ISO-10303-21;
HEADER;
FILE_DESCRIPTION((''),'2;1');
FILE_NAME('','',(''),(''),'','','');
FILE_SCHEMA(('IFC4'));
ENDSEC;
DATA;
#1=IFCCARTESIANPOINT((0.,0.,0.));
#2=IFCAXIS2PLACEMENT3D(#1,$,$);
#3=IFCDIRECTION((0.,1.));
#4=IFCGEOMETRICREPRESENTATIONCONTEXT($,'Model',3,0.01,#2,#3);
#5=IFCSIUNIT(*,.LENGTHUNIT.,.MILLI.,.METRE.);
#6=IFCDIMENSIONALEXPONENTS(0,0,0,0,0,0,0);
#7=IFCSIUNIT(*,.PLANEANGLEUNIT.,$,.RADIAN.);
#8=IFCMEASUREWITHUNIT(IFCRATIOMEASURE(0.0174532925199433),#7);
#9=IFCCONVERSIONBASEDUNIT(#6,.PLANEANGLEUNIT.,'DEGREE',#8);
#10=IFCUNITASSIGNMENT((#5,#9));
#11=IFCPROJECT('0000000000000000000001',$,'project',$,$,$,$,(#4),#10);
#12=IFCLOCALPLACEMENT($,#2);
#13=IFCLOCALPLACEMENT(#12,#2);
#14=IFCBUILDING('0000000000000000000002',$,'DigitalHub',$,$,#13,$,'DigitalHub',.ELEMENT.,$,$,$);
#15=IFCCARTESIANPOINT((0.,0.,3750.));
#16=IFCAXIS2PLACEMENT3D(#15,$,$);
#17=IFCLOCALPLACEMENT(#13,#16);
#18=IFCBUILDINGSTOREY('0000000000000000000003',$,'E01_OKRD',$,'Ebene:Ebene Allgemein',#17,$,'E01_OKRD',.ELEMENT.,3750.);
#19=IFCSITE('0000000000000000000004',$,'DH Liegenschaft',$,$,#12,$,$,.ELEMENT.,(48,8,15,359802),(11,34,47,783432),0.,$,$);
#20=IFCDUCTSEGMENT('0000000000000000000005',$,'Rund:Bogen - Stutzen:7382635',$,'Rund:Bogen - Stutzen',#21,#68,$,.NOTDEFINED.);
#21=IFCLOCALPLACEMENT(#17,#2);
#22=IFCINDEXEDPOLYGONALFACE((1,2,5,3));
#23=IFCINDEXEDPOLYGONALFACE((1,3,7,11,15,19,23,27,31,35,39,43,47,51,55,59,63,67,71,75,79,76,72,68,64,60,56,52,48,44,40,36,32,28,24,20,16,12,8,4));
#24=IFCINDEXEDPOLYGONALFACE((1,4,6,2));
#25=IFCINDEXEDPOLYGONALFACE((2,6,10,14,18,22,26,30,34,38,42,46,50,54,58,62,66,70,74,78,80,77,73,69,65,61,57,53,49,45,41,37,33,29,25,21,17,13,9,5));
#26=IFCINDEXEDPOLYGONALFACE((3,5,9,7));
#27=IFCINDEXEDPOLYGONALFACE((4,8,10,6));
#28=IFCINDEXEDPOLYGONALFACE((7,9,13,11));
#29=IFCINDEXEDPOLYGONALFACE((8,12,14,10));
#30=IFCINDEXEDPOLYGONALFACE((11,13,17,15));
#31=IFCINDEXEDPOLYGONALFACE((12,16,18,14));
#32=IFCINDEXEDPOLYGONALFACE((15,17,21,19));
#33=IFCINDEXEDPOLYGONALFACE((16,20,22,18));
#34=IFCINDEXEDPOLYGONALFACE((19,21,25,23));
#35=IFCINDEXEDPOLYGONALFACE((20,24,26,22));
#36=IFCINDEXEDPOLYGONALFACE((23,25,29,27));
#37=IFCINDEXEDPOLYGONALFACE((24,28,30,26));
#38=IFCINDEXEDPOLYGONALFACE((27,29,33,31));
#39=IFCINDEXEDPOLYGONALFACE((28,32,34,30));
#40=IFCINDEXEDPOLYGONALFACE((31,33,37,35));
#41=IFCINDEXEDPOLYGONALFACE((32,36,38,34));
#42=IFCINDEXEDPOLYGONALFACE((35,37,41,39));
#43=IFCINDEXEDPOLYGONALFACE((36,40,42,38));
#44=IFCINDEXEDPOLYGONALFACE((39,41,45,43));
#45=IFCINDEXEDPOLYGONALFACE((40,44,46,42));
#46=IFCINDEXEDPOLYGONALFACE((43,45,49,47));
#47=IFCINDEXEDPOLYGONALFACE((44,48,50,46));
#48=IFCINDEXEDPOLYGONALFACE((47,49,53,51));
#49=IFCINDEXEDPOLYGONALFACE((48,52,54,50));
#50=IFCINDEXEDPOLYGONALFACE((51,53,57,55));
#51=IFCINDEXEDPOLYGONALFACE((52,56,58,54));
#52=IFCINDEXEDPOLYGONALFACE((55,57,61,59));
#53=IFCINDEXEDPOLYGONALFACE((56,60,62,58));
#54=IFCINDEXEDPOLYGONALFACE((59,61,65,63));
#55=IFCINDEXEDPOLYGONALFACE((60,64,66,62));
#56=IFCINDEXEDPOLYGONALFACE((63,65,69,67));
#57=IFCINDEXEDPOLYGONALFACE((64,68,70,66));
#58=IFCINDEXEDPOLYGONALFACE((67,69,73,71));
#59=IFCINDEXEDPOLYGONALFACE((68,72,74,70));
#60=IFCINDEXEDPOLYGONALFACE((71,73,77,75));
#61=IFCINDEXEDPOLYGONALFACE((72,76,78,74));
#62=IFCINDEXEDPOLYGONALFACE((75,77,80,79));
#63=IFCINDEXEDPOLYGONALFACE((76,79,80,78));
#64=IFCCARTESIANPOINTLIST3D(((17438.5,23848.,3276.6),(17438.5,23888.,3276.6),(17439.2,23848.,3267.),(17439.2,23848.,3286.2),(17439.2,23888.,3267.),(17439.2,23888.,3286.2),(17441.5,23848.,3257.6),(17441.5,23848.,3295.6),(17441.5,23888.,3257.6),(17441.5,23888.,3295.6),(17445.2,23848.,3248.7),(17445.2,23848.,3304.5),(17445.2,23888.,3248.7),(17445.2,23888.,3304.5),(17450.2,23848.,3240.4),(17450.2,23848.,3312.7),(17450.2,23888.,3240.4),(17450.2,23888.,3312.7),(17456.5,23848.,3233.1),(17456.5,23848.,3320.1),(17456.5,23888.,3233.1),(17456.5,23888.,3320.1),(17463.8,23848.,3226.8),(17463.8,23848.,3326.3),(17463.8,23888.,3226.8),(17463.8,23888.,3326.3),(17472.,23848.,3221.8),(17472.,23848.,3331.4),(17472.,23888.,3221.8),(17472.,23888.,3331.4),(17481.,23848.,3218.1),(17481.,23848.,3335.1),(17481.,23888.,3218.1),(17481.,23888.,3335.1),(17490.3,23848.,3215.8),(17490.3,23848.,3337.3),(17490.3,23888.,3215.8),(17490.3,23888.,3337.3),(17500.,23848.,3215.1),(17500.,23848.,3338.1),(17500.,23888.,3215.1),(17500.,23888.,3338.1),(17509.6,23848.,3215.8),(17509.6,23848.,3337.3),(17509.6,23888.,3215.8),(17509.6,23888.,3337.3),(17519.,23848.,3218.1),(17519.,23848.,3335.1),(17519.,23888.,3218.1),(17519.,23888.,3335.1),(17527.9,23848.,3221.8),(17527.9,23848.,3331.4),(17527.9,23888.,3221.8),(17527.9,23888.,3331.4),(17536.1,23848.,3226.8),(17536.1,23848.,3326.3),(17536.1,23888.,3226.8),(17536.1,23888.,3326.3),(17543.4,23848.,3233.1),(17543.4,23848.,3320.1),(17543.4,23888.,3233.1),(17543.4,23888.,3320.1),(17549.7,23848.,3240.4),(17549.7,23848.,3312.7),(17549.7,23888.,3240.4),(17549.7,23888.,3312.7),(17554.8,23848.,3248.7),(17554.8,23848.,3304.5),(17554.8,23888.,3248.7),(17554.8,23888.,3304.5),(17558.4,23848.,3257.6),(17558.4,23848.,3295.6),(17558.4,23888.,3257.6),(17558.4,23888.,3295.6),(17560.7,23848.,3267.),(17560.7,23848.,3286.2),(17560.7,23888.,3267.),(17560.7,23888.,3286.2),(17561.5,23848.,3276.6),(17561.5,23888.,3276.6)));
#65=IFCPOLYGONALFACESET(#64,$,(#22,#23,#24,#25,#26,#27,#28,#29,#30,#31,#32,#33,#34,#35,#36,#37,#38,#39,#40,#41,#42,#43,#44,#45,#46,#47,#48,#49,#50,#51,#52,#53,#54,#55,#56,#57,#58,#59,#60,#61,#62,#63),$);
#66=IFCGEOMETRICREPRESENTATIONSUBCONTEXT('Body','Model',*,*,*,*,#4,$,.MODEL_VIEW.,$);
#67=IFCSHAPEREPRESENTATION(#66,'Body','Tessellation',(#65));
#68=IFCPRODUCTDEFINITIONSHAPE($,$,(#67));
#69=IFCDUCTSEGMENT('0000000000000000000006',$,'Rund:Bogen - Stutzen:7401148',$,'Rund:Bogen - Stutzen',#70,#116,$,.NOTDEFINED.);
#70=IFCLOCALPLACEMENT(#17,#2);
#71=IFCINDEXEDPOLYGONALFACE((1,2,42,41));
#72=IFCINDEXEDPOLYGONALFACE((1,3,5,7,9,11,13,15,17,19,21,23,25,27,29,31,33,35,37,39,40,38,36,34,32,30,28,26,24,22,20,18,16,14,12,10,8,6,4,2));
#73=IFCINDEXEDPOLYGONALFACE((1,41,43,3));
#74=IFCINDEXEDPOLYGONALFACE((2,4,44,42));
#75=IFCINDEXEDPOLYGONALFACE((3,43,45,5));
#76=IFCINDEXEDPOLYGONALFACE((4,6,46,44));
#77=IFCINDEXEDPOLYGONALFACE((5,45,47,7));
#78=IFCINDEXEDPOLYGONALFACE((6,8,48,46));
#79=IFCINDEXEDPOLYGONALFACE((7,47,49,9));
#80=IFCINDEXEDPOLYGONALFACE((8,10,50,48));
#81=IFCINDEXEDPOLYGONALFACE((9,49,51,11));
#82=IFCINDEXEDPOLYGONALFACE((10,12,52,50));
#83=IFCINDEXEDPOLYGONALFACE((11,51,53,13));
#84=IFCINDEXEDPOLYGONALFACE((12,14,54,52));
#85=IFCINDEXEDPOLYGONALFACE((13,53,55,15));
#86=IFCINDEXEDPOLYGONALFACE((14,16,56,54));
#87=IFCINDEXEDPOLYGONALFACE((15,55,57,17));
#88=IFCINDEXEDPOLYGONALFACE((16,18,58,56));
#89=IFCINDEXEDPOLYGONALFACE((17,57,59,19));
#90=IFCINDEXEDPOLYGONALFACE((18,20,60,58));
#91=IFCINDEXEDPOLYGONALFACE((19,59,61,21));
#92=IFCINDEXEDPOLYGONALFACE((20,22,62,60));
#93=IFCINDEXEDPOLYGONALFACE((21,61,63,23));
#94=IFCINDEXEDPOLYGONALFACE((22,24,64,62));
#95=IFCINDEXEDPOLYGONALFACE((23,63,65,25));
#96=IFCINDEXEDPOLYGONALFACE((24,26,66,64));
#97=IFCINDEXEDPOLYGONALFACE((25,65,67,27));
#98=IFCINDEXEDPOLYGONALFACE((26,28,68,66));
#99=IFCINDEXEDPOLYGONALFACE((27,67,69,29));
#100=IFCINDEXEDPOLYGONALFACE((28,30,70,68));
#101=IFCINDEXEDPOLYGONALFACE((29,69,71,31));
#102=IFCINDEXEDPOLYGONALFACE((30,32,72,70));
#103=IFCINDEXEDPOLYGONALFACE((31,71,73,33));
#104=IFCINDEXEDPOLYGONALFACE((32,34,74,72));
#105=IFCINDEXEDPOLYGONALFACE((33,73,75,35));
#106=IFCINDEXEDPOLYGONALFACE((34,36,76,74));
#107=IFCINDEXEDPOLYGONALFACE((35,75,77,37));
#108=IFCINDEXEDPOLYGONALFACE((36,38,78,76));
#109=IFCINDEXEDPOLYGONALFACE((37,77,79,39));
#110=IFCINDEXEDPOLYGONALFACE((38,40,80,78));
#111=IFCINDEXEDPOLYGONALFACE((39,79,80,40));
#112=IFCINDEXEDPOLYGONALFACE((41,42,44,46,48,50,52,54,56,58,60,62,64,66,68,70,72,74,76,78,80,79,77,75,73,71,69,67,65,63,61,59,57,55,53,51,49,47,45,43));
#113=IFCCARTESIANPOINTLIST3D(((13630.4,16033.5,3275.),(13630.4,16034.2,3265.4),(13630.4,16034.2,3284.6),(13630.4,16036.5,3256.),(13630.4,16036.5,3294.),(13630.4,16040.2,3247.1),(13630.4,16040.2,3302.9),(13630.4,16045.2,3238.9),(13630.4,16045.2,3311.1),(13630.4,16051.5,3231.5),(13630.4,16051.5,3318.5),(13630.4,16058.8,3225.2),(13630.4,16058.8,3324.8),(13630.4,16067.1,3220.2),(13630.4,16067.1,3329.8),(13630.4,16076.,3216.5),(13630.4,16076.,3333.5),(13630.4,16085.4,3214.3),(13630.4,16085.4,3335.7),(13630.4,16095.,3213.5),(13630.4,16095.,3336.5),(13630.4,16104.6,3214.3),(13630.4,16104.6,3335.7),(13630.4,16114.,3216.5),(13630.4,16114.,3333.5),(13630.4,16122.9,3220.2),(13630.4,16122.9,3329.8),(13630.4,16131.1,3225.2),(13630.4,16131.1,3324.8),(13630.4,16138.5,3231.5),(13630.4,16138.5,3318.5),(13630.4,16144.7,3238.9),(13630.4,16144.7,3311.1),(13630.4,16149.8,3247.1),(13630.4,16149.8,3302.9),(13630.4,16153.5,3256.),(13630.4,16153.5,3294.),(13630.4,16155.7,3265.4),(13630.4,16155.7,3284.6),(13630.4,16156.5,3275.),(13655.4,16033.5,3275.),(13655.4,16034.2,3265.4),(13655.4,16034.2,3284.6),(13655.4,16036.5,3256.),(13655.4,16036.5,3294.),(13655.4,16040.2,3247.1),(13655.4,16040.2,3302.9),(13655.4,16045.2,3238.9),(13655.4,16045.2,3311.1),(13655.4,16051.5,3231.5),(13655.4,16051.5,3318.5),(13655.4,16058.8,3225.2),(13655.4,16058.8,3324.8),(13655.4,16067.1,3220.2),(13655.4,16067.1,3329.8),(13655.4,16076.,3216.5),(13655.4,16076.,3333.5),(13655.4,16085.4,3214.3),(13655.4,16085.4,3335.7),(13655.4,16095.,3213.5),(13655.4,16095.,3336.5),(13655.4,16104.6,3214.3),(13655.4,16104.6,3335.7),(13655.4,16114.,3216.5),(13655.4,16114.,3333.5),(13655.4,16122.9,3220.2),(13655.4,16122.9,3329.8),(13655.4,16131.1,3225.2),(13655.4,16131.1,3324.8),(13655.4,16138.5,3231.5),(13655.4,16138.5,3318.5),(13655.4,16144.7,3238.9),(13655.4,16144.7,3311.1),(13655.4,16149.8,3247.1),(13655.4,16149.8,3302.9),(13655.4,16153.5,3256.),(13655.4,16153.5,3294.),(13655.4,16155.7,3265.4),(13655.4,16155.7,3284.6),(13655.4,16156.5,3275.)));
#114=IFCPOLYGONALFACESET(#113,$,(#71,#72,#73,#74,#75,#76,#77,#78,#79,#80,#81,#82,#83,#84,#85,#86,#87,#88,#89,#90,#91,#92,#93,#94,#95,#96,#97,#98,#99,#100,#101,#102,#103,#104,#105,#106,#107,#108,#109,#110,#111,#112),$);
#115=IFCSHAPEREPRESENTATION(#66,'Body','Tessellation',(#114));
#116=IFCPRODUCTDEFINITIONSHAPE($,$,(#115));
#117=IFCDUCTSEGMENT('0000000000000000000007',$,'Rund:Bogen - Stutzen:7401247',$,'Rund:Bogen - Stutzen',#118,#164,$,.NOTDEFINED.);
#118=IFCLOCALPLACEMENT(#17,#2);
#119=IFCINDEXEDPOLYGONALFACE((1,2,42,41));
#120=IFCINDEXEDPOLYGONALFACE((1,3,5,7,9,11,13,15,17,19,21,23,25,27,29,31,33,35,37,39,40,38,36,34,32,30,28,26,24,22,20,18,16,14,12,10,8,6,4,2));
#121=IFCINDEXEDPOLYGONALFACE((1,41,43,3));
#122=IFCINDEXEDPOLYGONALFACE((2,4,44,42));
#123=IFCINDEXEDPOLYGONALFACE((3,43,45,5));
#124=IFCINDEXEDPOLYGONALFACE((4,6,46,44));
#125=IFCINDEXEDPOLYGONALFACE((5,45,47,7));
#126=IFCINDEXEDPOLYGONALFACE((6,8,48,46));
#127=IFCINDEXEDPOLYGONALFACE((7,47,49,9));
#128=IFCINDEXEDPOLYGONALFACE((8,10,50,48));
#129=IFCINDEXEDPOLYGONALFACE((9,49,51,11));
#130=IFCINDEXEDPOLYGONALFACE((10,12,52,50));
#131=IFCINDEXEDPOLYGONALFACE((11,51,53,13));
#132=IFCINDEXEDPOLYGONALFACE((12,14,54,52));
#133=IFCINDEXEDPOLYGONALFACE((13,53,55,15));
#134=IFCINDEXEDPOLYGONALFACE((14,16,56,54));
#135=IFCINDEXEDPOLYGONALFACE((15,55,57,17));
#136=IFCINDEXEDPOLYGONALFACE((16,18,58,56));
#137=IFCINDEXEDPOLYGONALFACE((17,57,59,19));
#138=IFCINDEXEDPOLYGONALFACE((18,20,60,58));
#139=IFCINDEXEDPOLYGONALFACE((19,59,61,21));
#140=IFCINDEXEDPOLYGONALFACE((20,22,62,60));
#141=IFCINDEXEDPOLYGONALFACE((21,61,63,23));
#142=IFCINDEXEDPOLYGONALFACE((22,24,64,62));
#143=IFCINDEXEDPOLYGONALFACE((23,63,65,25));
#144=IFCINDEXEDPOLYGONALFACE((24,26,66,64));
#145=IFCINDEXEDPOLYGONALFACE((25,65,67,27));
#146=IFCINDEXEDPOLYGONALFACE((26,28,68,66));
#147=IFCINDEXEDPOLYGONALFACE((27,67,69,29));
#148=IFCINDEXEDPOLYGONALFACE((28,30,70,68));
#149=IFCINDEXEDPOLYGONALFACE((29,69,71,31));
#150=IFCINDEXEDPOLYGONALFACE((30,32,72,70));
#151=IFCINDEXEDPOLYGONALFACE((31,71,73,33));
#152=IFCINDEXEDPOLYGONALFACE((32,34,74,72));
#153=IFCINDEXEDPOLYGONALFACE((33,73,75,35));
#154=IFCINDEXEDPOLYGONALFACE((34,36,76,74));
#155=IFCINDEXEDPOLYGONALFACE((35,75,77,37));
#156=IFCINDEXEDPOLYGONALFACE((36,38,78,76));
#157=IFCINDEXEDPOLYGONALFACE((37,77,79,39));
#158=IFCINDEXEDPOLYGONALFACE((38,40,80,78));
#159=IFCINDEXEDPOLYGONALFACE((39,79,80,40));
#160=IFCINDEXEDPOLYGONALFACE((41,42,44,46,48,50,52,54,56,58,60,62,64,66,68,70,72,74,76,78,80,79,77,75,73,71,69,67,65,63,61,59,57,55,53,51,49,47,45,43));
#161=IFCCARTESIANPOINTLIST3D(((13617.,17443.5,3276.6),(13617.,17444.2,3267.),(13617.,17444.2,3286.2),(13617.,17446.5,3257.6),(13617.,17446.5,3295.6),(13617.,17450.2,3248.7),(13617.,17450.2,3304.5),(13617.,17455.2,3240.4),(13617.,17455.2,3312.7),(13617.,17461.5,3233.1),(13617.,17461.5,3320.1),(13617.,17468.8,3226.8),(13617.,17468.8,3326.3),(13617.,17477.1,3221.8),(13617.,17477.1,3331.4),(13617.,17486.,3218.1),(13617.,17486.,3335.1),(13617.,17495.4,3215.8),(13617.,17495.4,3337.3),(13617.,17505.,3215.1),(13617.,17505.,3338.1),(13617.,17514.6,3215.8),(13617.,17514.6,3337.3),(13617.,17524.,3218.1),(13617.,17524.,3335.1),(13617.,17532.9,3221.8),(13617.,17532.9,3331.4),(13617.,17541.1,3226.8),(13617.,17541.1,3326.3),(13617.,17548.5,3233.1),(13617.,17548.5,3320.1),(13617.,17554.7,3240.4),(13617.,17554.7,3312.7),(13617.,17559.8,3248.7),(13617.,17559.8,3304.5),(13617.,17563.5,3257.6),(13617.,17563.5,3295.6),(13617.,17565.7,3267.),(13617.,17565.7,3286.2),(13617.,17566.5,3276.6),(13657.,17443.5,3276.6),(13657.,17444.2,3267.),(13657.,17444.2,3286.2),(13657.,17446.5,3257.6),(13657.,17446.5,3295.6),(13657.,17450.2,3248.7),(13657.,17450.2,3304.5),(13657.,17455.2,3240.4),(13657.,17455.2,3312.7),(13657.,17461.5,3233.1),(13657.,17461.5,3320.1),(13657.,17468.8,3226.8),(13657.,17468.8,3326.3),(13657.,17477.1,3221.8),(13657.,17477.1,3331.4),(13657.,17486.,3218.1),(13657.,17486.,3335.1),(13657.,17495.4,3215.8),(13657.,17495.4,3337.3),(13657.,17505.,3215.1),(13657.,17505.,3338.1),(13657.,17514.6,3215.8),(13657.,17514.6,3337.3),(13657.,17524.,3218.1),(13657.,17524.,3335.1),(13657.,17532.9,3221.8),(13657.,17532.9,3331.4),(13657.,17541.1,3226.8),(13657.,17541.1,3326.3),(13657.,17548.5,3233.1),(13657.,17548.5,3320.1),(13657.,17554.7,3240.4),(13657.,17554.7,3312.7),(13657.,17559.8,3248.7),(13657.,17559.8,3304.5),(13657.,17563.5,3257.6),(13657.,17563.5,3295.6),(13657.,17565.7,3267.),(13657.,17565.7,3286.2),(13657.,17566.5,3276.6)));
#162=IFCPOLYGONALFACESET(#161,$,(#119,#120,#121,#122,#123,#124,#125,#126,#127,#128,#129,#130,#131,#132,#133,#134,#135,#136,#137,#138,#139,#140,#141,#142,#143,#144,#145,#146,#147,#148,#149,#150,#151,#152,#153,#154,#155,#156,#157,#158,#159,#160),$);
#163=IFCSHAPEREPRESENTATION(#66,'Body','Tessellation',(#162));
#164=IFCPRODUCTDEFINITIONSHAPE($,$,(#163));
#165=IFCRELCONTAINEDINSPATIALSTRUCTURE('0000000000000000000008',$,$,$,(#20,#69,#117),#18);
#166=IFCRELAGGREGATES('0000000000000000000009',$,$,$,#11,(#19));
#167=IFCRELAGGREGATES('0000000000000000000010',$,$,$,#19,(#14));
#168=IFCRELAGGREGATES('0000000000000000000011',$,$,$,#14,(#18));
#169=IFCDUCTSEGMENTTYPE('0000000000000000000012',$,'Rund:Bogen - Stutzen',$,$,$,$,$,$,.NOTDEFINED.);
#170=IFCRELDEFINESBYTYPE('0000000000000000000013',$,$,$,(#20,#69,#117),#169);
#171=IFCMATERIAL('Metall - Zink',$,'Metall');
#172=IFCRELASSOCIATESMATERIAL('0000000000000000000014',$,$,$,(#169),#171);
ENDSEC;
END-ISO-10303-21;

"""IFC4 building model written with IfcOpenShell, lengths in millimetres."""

from ifc_helpers import new_model, entity, si_unit, converted_unit, direction, frame, origin, place, context, subcontext, project, spatial, indexed_curve, outline, extrude, material, type_object, element, save


model = new_model("IFC4")

# Units and contexts
model_context = context("Model", 3, precision=0.01, world=origin(), true_north=direction((0.0, 1.0)))
body_context = subcontext(model_context, "Body", "Model", "MODEL_VIEW")
ifc_project = project(units=[si_unit("LENGTHUNIT", "METRE", prefix="MILLI"), converted_unit("PLANEANGLEUNIT", "DEGREE", entity("IfcRatioMeasure", 0.0174532925199433), si_unit("PLANEANGLEUNIT", "RADIAN"), dimensions=[0, 0, 0, 0, 0, 0, 0])], contexts=[model_context])

# Site, building, storey
site_placement = place(None, origin())
site = spatial("IfcSite", under=ifc_project, at=site_placement, Name="DH Liegenschaft", CompositionType="ELEMENT", RefLatitude=(48, 8, 15, 359802), RefLongitude=(11, 34, 47, 783432), RefElevation=0.0)
building_placement = place(site_placement, origin())
building = spatial("IfcBuilding", under=site, at=building_placement, Name="DigitalHub", LongName="DigitalHub", CompositionType="ELEMENT")
storey_placement = place(building_placement, frame((0.0, 0.0, 3750.0)))
storey = spatial("IfcBuildingStorey", under=building, at=storey_placement, Name="E01_OKRD", ObjectType="Ebene:Ebene Allgemein", LongName="E01_OKRD", CompositionType="ELEMENT", Elevation=3750.0)

# Shared definitions
ifc_material_1 = material(Name="Metall - Zink", Category="Metall")

# Duct segments
duct_segment_type_1 = type_object("IfcDuctSegmentType", Name="Rund:Bogen - Stutzen", PredefinedType="NOTDEFINED", material=ifc_material_1)
duct_segment_1_placement = place(storey_placement, frame((17436.9, 23848.0, 3213.5)))
element("IfcDuctSegment", 1, at=duct_segment_1_placement, inside=storey, type_object=duct_segment_type_1, Name="Rund:Bogen - Stutzen:7382635", ObjectType="Rund:Bogen - Stutzen", PredefinedType="NOTDEFINED", context=body_context, shape_type="SweptSolid", body=[
    extrude(outline(indexed_curve([(61.5, 0.0), (60.7, 9.6), (58.5, 19.0), (54.8, 27.9), (49.8, 36.1), (43.5, 43.5), (36.1, 49.8), (27.9, 54.8), (19.0, 58.5), (9.6, 60.7), (0.0, 61.5), (-9.6, 60.7), (-19.0, 58.5), (-27.9, 54.8), (-36.1, 49.8), (-43.5, 43.5), (-49.8, 36.1), (-54.8, 27.9), (-58.5, 19.0), (-60.7, 9.6), (-61.5, 0.0), (-60.7, -9.6), (-58.5, -19.0), (-54.8, -27.9), (-49.8, -36.1), (-43.5, -43.5), (-36.1, -49.8), (-27.9, -54.8), (-19.0, -58.5), (-9.6, -60.7), (0.0, -61.5), (9.6, -60.7), (19.0, -58.5), (27.9, -54.8), (36.1, -49.8), (43.5, -43.5), (49.8, -36.1), (54.8, -27.9), (58.5, -19.0), (60.7, -9.6), (61.5, 0.0)], self_intersect=False)), frame((63.1, 0.0, 63.1), z_axis=(0.0, 1.0, 0.0), x_axis=(1.0, 0.0, 0.0)), (0.0, 0.0, 1.0), 40.0),
])
duct_segment_2_placement = place(storey_placement, frame((13630.4, 16031.9, 3211.9)))
element("IfcDuctSegment", 2, at=duct_segment_2_placement, inside=storey, type_object=duct_segment_type_1, Name="Rund:Bogen - Stutzen:7401148", ObjectType="Rund:Bogen - Stutzen", PredefinedType="NOTDEFINED", context=body_context, shape_type="SweptSolid", body=[
    extrude(outline(indexed_curve([(61.5, 0.0), (60.7, 9.6), (58.5, 19.0), (54.8, 27.9), (49.8, 36.1), (43.5, 43.5), (36.1, 49.8), (27.9, 54.8), (19.0, 58.5), (9.6, 60.7), (0.0, 61.5), (-9.6, 60.7), (-19.0, 58.5), (-27.9, 54.8), (-36.1, 49.8), (-43.5, 43.5), (-49.8, 36.1), (-54.8, 27.9), (-58.5, 19.0), (-60.7, 9.6), (-61.5, 0.0), (-60.7, -9.6), (-58.5, -19.0), (-54.8, -27.9), (-49.8, -36.1), (-43.5, -43.5), (-36.1, -49.8), (-27.9, -54.8), (-19.0, -58.5), (-9.6, -60.7), (0.0, -61.5), (9.6, -60.7), (19.0, -58.5), (27.9, -54.8), (36.1, -49.8), (43.5, -43.5), (49.8, -36.1), (54.8, -27.9), (58.5, -19.0), (60.7, -9.6), (61.5, 0.0)], self_intersect=False)), frame((0.0, 63.1, 63.1), z_axis=(1.0, 0.0, 0.0), x_axis=(0.0, 1.0, 0.0)), (0.0, 0.0, 1.0), 25.0),
])
duct_segment_3_placement = place(storey_placement, frame((13617.0, 17441.9, 3213.5)))
element("IfcDuctSegment", 3, at=duct_segment_3_placement, inside=storey, type_object=duct_segment_type_1, Name="Rund:Bogen - Stutzen:7401247", ObjectType="Rund:Bogen - Stutzen", PredefinedType="NOTDEFINED", context=body_context, shape_type="SweptSolid", body=[
    extrude(outline(indexed_curve([(61.5, 0.0), (60.7, 9.6), (58.5, 19.0), (54.8, 27.9), (49.8, 36.1), (43.5, 43.5), (36.1, 49.8), (27.9, 54.8), (19.0, 58.5), (9.6, 60.7), (0.0, 61.5), (-9.6, 60.7), (-19.0, 58.5), (-27.9, 54.8), (-36.1, 49.8), (-43.5, 43.5), (-49.8, 36.1), (-54.8, 27.9), (-58.5, 19.0), (-60.7, 9.6), (-61.5, 0.0), (-60.7, -9.6), (-58.5, -19.0), (-54.8, -27.9), (-49.8, -36.1), (-43.5, -43.5), (-36.1, -49.8), (-27.9, -54.8), (-19.0, -58.5), (-9.6, -60.7), (0.0, -61.5), (9.6, -60.7), (19.0, -58.5), (27.9, -54.8), (36.1, -49.8), (43.5, -43.5), (49.8, -36.1), (54.8, -27.9), (58.5, -19.0), (60.7, -9.6), (61.5, 0.0)], self_intersect=False)), frame((0.0, 63.1, 63.1), z_axis=(1.0, 0.0, 0.0), x_axis=(0.0, 1.0, 0.0)), (0.0, 0.0, 1.0), 40.0),
])

save(model, "model.ifc")
